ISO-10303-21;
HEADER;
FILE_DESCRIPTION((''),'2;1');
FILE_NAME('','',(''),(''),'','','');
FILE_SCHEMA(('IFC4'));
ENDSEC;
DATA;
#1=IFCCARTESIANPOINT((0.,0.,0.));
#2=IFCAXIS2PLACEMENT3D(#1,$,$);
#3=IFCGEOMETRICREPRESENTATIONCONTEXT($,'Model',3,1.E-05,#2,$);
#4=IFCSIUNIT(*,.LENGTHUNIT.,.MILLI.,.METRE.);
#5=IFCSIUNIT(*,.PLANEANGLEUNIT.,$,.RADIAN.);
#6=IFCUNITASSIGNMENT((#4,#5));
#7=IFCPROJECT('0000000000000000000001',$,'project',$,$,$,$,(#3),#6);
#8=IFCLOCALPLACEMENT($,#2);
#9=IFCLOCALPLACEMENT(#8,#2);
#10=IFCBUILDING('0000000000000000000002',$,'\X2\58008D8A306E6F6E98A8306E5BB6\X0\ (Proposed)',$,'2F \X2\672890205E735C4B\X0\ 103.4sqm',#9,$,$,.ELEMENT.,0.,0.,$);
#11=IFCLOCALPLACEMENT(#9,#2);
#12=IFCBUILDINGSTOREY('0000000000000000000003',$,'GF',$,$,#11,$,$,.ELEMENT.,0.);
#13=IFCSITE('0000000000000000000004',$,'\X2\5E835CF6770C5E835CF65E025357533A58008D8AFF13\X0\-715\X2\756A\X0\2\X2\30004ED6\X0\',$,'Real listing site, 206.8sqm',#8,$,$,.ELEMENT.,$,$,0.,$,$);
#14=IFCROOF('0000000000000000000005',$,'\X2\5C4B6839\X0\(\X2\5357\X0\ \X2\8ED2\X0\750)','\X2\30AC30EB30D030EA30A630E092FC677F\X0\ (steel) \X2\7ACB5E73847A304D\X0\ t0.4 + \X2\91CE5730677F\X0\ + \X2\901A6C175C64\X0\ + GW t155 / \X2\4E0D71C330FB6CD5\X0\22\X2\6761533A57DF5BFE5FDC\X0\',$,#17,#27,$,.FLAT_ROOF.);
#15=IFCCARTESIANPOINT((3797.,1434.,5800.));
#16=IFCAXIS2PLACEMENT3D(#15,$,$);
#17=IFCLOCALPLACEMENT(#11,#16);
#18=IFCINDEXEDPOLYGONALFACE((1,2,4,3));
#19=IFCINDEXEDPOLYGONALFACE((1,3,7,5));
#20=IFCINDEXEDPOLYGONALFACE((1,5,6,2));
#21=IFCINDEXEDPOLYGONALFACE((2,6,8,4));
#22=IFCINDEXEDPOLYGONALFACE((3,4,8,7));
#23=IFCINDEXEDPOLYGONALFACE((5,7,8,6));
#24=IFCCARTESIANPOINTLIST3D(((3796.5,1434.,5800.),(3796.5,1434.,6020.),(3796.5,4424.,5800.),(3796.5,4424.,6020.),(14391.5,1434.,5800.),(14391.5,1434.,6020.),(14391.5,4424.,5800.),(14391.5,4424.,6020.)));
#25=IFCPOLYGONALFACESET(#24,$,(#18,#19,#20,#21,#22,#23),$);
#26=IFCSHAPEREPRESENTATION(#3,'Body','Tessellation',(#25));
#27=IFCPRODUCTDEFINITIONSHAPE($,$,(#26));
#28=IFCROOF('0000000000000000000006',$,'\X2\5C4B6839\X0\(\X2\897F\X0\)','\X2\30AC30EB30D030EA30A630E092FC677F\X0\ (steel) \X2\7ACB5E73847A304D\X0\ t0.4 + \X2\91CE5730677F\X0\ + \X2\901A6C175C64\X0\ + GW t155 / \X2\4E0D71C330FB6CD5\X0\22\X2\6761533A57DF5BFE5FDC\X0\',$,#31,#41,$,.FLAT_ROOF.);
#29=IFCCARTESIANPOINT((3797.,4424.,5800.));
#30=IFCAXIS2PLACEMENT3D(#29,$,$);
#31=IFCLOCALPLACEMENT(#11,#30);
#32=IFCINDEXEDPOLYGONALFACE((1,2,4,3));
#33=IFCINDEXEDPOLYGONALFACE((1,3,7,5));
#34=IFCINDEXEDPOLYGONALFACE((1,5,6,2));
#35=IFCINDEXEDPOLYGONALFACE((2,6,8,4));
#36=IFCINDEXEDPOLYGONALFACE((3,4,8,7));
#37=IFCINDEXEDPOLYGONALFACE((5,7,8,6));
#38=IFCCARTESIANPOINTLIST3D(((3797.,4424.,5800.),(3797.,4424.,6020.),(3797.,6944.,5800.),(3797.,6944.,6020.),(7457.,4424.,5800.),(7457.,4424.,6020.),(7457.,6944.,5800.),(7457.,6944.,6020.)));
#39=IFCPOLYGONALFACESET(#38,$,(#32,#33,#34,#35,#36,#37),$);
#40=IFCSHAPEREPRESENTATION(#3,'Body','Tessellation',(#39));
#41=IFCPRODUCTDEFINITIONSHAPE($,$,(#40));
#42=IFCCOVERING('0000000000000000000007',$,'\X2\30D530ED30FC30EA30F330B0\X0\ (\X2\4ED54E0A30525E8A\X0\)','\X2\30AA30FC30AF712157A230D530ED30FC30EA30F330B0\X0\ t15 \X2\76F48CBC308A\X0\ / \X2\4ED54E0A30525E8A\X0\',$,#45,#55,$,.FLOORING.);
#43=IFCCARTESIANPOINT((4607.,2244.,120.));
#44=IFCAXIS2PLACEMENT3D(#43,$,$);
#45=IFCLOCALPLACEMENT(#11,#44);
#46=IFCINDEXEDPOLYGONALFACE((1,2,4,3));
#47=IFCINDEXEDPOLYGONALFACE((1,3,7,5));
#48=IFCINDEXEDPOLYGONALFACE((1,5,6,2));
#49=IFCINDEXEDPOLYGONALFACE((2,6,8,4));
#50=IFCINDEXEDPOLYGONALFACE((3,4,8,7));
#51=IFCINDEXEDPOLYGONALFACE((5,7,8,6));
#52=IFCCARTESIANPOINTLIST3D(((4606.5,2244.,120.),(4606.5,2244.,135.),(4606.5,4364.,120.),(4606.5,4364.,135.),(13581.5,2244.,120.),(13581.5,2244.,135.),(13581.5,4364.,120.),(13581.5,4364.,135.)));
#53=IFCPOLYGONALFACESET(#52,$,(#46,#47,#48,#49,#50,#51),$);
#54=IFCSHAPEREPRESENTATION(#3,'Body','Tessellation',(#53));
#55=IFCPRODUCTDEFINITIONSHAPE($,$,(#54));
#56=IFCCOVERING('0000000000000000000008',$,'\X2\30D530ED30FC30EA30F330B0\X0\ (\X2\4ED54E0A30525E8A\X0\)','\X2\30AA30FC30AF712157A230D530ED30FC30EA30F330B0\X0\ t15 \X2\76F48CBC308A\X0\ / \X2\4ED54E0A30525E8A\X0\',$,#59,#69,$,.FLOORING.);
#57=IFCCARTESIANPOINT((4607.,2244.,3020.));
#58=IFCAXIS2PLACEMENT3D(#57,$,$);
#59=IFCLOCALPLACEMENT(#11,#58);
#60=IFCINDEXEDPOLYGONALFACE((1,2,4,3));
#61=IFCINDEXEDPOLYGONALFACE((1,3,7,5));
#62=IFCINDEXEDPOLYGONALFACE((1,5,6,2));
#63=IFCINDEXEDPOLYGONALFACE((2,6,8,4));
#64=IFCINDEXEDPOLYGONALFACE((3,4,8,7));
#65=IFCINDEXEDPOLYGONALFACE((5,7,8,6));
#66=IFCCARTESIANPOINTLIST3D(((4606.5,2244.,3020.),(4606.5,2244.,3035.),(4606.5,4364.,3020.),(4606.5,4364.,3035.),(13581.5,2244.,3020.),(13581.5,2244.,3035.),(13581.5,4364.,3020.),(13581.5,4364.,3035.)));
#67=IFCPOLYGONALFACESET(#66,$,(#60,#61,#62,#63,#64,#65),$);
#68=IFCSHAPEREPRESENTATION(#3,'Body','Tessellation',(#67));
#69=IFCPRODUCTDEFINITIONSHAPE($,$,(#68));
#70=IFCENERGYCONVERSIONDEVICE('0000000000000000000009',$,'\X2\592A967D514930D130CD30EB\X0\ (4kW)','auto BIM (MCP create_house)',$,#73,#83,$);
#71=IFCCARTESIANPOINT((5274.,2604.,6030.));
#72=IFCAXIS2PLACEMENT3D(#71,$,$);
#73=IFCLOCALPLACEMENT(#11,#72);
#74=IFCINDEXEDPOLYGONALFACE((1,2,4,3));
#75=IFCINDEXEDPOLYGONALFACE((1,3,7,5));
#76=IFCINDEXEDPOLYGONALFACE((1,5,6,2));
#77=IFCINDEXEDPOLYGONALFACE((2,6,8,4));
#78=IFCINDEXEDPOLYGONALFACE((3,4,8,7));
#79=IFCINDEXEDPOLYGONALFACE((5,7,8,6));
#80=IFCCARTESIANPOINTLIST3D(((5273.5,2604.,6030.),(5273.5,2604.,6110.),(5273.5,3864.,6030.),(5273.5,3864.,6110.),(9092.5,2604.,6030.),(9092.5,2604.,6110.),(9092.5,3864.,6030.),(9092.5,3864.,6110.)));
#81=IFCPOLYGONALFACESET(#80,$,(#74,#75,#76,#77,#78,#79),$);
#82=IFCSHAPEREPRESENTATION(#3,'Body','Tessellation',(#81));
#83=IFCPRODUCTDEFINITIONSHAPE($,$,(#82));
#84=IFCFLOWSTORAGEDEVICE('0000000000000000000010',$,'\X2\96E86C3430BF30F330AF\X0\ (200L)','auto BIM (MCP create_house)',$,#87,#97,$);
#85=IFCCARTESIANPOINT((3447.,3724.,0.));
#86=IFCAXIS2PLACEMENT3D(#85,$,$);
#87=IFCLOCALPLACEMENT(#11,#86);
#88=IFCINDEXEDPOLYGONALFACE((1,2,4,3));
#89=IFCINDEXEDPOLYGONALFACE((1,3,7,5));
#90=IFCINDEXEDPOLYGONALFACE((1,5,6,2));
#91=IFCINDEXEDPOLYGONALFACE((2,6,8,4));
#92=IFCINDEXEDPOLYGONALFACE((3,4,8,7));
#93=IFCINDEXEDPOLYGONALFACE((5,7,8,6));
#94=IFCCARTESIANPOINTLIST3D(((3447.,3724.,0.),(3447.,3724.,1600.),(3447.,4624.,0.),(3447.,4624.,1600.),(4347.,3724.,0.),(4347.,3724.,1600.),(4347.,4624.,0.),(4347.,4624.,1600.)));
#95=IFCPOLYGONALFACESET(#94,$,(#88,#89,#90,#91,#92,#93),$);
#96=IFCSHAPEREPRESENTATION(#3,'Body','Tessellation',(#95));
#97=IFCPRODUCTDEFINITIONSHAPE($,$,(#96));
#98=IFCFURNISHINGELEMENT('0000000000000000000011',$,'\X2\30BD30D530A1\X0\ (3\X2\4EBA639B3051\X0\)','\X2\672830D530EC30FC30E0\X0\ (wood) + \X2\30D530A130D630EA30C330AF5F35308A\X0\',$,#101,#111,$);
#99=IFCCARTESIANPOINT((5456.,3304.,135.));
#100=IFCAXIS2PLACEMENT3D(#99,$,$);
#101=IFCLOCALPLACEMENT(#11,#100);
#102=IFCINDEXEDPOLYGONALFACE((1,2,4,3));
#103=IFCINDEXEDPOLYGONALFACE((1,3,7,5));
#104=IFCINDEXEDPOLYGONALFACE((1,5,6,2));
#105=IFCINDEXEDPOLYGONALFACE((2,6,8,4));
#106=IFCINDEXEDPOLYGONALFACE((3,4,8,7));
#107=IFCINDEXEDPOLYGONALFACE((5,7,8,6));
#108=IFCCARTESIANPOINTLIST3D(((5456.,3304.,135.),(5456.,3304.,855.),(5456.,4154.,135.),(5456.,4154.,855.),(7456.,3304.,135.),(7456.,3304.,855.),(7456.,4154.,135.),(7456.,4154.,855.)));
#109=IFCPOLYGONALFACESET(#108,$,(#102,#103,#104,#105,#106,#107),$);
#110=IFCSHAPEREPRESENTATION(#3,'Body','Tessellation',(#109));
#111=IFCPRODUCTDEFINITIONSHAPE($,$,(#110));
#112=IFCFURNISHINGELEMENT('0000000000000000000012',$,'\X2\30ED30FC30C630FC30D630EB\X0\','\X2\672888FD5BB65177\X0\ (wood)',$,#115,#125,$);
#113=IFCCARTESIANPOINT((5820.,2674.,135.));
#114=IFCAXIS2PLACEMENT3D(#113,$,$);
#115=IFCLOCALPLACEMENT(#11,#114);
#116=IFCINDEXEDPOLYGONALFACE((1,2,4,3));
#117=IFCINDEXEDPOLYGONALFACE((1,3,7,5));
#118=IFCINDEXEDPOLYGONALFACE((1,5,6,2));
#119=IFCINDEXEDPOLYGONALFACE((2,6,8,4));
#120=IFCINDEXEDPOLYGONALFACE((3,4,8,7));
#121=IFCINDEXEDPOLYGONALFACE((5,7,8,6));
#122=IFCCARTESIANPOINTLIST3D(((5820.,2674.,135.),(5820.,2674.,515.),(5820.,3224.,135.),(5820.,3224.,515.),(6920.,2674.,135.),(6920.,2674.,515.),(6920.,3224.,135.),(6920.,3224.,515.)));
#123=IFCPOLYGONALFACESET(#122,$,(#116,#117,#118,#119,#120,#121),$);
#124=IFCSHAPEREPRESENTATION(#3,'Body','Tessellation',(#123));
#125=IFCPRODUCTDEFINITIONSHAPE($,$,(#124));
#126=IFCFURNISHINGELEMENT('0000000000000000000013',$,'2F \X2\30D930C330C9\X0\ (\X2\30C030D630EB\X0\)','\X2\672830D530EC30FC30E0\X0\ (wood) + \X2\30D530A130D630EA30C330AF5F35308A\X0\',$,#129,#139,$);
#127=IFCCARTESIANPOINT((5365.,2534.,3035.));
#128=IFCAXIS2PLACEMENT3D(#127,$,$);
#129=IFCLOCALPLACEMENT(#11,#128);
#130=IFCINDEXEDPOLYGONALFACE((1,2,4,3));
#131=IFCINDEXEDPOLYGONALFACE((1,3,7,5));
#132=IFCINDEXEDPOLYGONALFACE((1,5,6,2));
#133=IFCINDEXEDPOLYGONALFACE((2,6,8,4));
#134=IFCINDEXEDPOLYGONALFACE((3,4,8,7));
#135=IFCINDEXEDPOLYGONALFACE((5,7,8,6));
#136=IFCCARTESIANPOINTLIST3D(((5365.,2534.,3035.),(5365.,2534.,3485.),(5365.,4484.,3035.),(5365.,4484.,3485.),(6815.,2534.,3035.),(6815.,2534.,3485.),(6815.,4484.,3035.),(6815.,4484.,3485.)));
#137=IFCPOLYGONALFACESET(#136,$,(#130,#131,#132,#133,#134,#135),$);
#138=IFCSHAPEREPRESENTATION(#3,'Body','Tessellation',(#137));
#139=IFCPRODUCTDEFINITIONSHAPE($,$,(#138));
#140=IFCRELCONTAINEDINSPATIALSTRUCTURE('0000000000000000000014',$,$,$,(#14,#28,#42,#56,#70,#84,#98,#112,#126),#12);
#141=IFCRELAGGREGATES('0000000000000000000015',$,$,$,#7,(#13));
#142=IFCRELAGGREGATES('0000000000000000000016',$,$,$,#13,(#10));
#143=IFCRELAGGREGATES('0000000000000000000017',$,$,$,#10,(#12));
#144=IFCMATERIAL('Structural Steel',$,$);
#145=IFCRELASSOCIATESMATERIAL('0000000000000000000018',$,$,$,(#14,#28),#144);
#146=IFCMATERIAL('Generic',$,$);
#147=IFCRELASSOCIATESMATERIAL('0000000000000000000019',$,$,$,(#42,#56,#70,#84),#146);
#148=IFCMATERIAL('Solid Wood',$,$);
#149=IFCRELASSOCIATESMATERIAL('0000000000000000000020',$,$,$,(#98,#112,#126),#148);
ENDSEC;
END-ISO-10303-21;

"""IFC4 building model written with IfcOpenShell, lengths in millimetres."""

from ifc_helpers import new_model, si_unit, frame, frame_2d, origin, place, context, project, spatial, rectangle, extrude, material, element, save


model = new_model("IFC4")

# Units and contexts
model_context = context("Model", 3, precision=1e-05, world=origin())
ifc_project = project(units=[si_unit("LENGTHUNIT", "METRE", prefix="MILLI"), si_unit("PLANEANGLEUNIT", "RADIAN")], contexts=[model_context])

# Site, building, storey
site_placement = place(None, origin())
site = spatial("IfcSite", under=ifc_project, at=site_placement, Name="広島県広島市南区堀越３-715番2　他", ObjectType="Real listing site, 206.8sqm", CompositionType="ELEMENT", RefElevation=0.0)
building_placement = place(site_placement, origin())
building = spatial("IfcBuilding", under=site, at=building_placement, Name="堀越の潮風の家 (Proposed)", ObjectType="2F 木造平屋 103.4sqm", CompositionType="ELEMENT", ElevationOfRefHeight=0.0, ElevationOfTerrain=0.0)
storey_placement = place(building_placement, origin())
storey = spatial("IfcBuildingStorey", under=building, at=storey_placement, Name="GF", CompositionType="ELEMENT", Elevation=0.0)

# Shared definitions
ifc_material_1 = material(Name="Solid Wood")

# Roofs
ifc_material_2 = material(Name="Structural Steel")
roof_1_placement = place(storey_placement, frame((3797.0, 1434.0, 5800.0)))
element("IfcRoof", 1, at=roof_1_placement, inside=storey, material=ifc_material_2, Name="屋根(南 軒750)", Description="ガルバリウム鋼板 (steel) 立平葺き t0.4 + 野地板 + 通気層 + GW t155 / 不燃・法22条区域対応", PredefinedType="FLAT_ROOF", context=model_context, shape_type="SweptSolid", body=[
    extrude(rectangle(XDim=10595.0, YDim=2990.0, at=frame_2d((5297.0, 1495.0))), frame((3797.0, 1434.0, 5800.0)), (0.0, 0.0, 1.0), 220.0),
])
roof_2_placement = place(storey_placement, frame((3797.0, 4424.0, 5800.0)))
element("IfcRoof", 2, at=roof_2_placement, inside=storey, material=ifc_material_2, Name="屋根(西)", Description="ガルバリウム鋼板 (steel) 立平葺き t0.4 + 野地板 + 通気層 + GW t155 / 不燃・法22条区域対応", PredefinedType="FLAT_ROOF", context=model_context, shape_type="SweptSolid", body=[
    extrude(rectangle(XDim=3660.0, YDim=2520.0, at=frame_2d((1830.0, 1260.0))), frame((3797.0, 4424.0, 5800.0)), (0.0, 0.0, 1.0), 220.0),
])

# Coverings
ifc_material_3 = material(Name="Generic")
covering_1_placement = place(storey_placement, frame((4607.0, 2244.0, 120.0)))
element("IfcCovering", 3, at=covering_1_placement, inside=storey, material=ifc_material_3, Name="フローリング (仕上げ床)", Description="オーク無垢フローリング t15 直貼り / 仕上げ床", PredefinedType="FLOORING", context=model_context, shape_type="SweptSolid", body=[
    extrude(rectangle(XDim=8975.0, YDim=2120.0, at=frame_2d((4487.0, 1060.0))), frame((4607.0, 2244.0, 120.0)), (0.0, 0.0, 1.0), 15.0),
])
covering_2_placement = place(storey_placement, frame((4607.0, 2244.0, 3020.0)))
element("IfcCovering", 4, at=covering_2_placement, inside=storey, material=ifc_material_3, Name="フローリング (仕上げ床)", Description="オーク無垢フローリング t15 直貼り / 仕上げ床", PredefinedType="FLOORING", context=model_context, shape_type="SweptSolid", body=[
    extrude(rectangle(XDim=8975.0, YDim=2120.0, at=frame_2d((4487.0, 1060.0))), frame((4607.0, 2244.0, 3020.0)), (0.0, 0.0, 1.0), 15.0),
])

# Energy conversion device
energy_conversion_device_placement = place(storey_placement, frame((5274.0, 2604.0, 6030.0)))
element("IfcEnergyConversionDevice", 5, at=energy_conversion_device_placement, inside=storey, material=ifc_material_3, Name="太陽光パネル (4kW)", Description="auto BIM (MCP create_house)", context=model_context, shape_type="SweptSolid", body=[
    extrude(rectangle(XDim=3819.0, YDim=1260.0, at=frame_2d((1909.0, 630.0))), frame((5274.0, 2604.0, 6030.0)), (0.0, 0.0, 1.0), 80.0),
])

# Flow storage device
flow_storage_device_placement = place(storey_placement, frame((3447.0, 3724.0, 0.0)))
element("IfcFlowStorageDevice", 6, at=flow_storage_device_placement, inside=storey, material=ifc_material_3, Name="雨水タンク (200L)", Description="auto BIM (MCP create_house)", context=model_context, shape_type="SweptSolid", body=[
    extrude(rectangle(XDim=900.0, YDim=900.0, at=frame_2d((450.0, 450.0))), frame((3447.0, 3724.0, 0.0)), (0.0, 0.0, 1.0), 1600.0),
])

# Furnishing elements
furnishing_1_placement = place(storey_placement, frame((5456.0, 3304.0, 135.0)))
element("IfcFurnishingElement", 7, at=furnishing_1_placement, inside=storey, material=ifc_material_1, Name="ソファ (3人掛け)", Description="木フレーム (wood) + ファブリック張り", context=model_context, shape_type="SweptSolid", body=[
    extrude(rectangle(XDim=2000.0, YDim=850.0, at=frame_2d((1000.0, 425.0))), frame((5456.0, 3304.0, 135.0)), (0.0, 0.0, 1.0), 720.0),
])
furnishing_2_placement = place(storey_placement, frame((5820.0, 2674.0, 135.0)))
element("IfcFurnishingElement", 8, at=furnishing_2_placement, inside=storey, material=ifc_material_1, Name="ローテーブル", Description="木製家具 (wood)", context=model_context, shape_type="SweptSolid", body=[
    extrude(rectangle(XDim=1100.0, YDim=550.0, at=frame_2d((550.0, 275.0))), frame((5820.0, 2674.0, 135.0)), (0.0, 0.0, 1.0), 380.0),
])
furnishing_3_placement = place(storey_placement, frame((5365.0, 2534.0, 3035.0)))
element("IfcFurnishingElement", 9, at=furnishing_3_placement, inside=storey, material=ifc_material_1, Name="2F ベッド (ダブル)", Description="木フレーム (wood) + ファブリック張り", context=model_context, shape_type="SweptSolid", body=[
    extrude(rectangle(XDim=1450.0, YDim=1950.0, at=frame_2d((725.0, 975.0))), frame((5365.0, 2534.0, 3035.0)), (0.0, 0.0, 1.0), 450.0),
])

save(model, "model.ifc")
